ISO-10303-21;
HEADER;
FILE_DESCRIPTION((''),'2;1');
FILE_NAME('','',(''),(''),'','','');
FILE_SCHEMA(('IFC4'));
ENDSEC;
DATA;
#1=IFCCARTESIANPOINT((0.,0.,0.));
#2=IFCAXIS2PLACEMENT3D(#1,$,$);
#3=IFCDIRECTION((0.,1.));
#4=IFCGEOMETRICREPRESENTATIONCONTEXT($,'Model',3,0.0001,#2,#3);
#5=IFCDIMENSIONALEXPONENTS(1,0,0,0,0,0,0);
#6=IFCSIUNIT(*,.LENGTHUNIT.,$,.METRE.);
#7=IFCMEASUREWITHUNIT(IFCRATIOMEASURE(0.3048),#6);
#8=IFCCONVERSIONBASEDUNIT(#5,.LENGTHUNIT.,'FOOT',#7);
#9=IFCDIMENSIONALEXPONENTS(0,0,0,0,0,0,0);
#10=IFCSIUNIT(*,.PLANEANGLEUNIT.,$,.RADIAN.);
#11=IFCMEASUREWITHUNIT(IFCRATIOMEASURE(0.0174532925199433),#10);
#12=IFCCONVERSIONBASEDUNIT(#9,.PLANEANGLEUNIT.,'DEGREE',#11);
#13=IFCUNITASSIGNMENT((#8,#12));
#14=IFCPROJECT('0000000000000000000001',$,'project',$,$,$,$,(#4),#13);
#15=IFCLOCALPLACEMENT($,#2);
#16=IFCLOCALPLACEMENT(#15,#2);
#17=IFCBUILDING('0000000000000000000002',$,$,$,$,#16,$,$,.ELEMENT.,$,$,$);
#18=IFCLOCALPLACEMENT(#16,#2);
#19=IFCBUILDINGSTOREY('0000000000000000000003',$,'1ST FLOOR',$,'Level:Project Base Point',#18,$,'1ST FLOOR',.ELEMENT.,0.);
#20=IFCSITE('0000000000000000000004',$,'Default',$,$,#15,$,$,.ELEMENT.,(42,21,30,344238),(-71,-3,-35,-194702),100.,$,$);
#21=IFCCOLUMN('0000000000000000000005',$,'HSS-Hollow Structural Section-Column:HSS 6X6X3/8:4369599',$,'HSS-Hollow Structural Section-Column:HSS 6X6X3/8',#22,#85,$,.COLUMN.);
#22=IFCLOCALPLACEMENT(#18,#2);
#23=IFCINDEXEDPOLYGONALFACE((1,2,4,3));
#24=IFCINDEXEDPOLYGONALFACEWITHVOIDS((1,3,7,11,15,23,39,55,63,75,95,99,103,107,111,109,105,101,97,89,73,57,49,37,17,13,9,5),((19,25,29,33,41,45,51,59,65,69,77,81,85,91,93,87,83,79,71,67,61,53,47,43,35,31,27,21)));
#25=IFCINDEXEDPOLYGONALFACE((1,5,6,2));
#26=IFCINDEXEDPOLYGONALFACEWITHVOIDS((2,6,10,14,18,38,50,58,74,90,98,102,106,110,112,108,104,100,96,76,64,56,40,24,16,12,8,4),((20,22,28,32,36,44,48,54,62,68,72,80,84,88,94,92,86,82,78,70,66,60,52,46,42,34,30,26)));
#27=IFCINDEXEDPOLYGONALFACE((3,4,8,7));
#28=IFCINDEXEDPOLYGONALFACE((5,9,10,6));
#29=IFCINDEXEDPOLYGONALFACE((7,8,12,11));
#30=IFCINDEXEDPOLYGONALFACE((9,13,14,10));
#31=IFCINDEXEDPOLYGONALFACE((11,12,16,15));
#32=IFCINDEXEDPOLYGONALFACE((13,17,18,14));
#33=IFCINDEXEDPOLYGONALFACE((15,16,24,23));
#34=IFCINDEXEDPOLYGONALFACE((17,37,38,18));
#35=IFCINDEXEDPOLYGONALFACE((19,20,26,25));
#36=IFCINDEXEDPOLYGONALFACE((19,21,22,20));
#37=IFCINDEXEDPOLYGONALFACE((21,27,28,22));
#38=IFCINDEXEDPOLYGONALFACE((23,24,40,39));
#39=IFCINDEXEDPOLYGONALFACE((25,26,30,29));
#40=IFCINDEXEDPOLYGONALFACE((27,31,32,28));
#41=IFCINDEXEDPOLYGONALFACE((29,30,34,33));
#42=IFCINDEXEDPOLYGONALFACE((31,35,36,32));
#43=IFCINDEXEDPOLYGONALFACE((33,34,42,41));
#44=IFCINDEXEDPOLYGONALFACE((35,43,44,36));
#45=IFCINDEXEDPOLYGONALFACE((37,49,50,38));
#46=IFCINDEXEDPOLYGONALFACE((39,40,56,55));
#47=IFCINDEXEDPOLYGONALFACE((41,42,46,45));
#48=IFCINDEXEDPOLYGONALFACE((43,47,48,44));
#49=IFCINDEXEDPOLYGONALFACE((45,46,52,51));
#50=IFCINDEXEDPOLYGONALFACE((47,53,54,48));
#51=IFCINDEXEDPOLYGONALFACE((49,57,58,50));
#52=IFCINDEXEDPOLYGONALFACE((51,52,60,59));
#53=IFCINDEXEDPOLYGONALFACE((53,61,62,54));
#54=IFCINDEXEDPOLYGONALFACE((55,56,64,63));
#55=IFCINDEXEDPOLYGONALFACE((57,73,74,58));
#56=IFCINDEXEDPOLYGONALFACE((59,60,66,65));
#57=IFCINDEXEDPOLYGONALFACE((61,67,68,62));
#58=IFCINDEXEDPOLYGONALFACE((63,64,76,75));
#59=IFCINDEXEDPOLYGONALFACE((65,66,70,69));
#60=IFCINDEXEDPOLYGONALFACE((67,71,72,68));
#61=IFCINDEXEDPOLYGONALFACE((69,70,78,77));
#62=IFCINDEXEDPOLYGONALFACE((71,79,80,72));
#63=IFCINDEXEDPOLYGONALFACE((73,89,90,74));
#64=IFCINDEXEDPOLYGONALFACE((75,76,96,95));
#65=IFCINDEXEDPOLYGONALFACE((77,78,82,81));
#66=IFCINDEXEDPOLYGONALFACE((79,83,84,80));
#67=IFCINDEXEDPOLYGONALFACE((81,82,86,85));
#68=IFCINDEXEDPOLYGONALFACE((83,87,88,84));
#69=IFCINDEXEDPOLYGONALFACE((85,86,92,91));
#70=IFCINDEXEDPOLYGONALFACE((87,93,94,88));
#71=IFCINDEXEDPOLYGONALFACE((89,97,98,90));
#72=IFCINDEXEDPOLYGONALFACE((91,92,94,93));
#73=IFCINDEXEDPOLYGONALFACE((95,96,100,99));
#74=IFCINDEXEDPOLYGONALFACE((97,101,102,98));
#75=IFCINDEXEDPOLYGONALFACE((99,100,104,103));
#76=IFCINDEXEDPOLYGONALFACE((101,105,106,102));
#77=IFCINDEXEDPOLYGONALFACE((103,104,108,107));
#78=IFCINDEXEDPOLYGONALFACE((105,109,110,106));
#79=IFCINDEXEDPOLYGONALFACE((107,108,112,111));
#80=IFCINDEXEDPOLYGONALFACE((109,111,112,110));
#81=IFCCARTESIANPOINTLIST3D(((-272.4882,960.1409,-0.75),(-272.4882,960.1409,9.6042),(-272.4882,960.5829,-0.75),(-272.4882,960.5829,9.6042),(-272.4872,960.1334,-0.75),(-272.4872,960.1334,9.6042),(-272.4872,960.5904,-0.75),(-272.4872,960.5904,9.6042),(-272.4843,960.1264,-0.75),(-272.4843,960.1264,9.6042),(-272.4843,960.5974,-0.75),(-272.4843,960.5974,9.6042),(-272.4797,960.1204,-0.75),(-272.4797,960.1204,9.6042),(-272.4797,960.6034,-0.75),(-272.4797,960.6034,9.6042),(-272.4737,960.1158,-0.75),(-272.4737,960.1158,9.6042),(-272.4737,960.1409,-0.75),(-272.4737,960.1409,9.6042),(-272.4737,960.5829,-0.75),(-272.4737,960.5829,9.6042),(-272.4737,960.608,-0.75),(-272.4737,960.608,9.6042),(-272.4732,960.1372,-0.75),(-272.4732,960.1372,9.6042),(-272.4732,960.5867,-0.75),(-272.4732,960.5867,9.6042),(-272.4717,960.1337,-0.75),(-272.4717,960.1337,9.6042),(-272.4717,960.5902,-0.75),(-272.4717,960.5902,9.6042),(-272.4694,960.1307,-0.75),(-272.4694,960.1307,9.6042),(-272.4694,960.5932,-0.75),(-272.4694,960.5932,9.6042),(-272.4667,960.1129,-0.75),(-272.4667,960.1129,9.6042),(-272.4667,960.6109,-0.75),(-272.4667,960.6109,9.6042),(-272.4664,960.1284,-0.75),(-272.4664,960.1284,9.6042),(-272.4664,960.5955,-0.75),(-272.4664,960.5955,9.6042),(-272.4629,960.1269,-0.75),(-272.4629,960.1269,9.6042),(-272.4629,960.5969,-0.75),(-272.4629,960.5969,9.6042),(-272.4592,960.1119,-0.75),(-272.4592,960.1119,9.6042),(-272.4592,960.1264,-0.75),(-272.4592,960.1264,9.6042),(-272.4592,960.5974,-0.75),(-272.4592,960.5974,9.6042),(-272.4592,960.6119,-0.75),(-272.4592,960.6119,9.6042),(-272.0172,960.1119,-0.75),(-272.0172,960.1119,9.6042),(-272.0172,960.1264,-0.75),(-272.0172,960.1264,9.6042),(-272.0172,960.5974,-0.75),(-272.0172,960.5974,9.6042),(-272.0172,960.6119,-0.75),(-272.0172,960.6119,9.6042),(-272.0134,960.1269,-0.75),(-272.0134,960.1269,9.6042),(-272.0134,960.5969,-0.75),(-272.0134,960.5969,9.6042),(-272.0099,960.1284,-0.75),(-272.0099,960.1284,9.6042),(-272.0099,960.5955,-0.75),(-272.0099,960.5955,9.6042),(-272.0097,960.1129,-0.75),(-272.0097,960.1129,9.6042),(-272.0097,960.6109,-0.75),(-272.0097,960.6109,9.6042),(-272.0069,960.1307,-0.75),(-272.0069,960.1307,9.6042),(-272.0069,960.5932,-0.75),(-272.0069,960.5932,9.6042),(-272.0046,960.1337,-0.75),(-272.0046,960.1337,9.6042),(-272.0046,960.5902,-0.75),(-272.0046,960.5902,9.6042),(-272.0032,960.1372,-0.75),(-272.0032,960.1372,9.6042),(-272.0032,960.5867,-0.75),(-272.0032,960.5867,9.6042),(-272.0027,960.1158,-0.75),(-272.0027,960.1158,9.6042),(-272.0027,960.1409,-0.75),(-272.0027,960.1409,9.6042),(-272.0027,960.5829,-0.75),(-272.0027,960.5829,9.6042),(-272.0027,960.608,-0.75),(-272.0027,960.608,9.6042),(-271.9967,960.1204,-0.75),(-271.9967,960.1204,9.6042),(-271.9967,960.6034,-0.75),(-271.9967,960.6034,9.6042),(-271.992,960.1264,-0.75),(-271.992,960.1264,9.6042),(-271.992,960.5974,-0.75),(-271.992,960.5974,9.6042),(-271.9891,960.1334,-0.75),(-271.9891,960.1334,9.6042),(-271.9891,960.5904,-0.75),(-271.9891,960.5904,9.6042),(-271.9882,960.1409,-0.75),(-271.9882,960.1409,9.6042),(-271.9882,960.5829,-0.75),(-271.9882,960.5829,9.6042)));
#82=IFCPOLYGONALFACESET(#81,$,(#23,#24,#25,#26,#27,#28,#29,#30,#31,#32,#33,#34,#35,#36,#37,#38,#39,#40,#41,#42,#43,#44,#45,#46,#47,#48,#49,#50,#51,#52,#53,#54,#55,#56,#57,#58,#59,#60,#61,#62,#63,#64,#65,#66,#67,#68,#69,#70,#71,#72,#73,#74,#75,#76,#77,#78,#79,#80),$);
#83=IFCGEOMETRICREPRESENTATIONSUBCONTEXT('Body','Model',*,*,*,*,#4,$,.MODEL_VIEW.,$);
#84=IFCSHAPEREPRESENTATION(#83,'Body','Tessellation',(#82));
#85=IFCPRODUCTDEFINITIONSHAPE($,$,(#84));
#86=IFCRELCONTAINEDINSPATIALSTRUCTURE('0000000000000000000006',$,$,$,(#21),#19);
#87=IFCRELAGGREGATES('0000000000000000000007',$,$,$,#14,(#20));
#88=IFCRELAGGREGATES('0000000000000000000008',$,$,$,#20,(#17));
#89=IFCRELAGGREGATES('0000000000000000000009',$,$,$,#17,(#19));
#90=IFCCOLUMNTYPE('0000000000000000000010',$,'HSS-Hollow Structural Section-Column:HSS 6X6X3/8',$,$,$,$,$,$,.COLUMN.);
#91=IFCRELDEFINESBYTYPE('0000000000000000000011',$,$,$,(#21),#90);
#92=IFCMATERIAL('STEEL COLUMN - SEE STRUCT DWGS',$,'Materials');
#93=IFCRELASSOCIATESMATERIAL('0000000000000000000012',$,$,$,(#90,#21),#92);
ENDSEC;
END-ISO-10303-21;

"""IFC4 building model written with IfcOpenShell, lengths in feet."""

from ifc_helpers import new_model, entity, si_unit, converted_unit, direction, frame, frame_2d, origin, place, context, subcontext, project, spatial, polyline, circle_curve, parameter, trimmed, segment, composite_curve, outline, extrude, source, transform, mapped, material, material_profile, profile_set, profile_usage, type_object, type_shapes, element, save


model = new_model("IFC4")

# Units and contexts
model_context = context("Model", 3, precision=0.0001, world=origin(), true_north=direction((0.0, 1.0)))
body_context = subcontext(model_context, "Body", "Model", "MODEL_VIEW")
ifc_project = project(units=[converted_unit("LENGTHUNIT", "FOOT", entity("IfcRatioMeasure", 0.3048), si_unit("LENGTHUNIT", "METRE"), dimensions=[1, 0, 0, 0, 0, 0, 0]), converted_unit("PLANEANGLEUNIT", "DEGREE", entity("IfcRatioMeasure", 0.0174532925199433), si_unit("PLANEANGLEUNIT", "RADIAN"), dimensions=[0, 0, 0, 0, 0, 0, 0])], contexts=[model_context])

# Site, building, storey
site_placement = place(None, origin())
site = spatial("IfcSite", under=ifc_project, at=site_placement, Name="Default", CompositionType="ELEMENT", RefLatitude=(42, 21, 30, 344238), RefLongitude=(-71, -3, -35, -194702), RefElevation=100.0)
building_placement = place(site_placement, origin())
building = spatial("IfcBuilding", under=site, at=building_placement, CompositionType="ELEMENT")
storey_placement = place(building_placement, origin())
storey = spatial("IfcBuildingStorey", under=building, at=storey_placement, Name="1ST FLOOR", ObjectType="Level:Project Base Point", LongName="1ST FLOOR", CompositionType="ELEMENT", Elevation=0.0)

# Column
ifc_material_1 = material(Name="STEEL COLUMN - SEE STRUCT DWGS", Category="Materials")
ifc_material_profile_1 = material_profile(ifc_material_1, outline(composite_curve([segment(trimmed(circle_curve(frame_2d((0.221, -0.221), x_axis=(1.0, 0.0)), 0.029), [parameter(270.0)], [parameter(0.0)], True, "PARAMETER"), True, "CONTINUOUS"), segment(polyline([(0.25, -0.221), (0.25, 0.221)]), True, "CONTINUOUS"), segment(trimmed(circle_curve(frame_2d((0.221, 0.221), x_axis=(1.0, 0.0)), 0.029), [parameter(0.0)], [parameter(90.0)], True, "PARAMETER"), True, "CONTINUOUS"), segment(polyline([(0.221, 0.25), (-0.221, 0.25)]), True, "CONTINUOUS"), segment(trimmed(circle_curve(frame_2d((-0.221, 0.221), x_axis=(1.0, 0.0)), 0.029), [parameter(90.0)], [parameter(180.0)], True, "PARAMETER"), True, "CONTINUOUS"), segment(polyline([(-0.25, 0.221), (-0.25, -0.221)]), True, "CONTINUOUS"), segment(trimmed(circle_curve(frame_2d((-0.221, -0.221), x_axis=(1.0, 0.0)), 0.029), [parameter(180.0)], [parameter(270.0)], True, "PARAMETER"), True, "CONTINUOUS"), segment(polyline([(-0.221, -0.25), (0.221, -0.25)]), True, "CONTINUOUS")], self_intersect=False), holes=[composite_curve([segment(polyline([(0.221, -0.2355), (-0.221, -0.2355)]), True, "CONTINUOUS"), segment(trimmed(circle_curve(frame_2d((-0.221, -0.221), x_axis=(1.0, 0.0)), 0.0145), [parameter(180.0)], [parameter(270.0)], True, "PARAMETER"), False, "CONTINUOUS"), segment(polyline([(-0.2355, -0.221), (-0.2355, 0.221)]), True, "CONTINUOUS"), segment(trimmed(circle_curve(frame_2d((-0.221, 0.221), x_axis=(1.0, 0.0)), 0.0145), [parameter(90.0)], [parameter(180.0)], True, "PARAMETER"), False, "CONTINUOUS"), segment(polyline([(-0.221, 0.2355), (0.221, 0.2355)]), True, "CONTINUOUS"), segment(trimmed(circle_curve(frame_2d((0.221, 0.221), x_axis=(1.0, 0.0)), 0.0145), [parameter(0.0)], [parameter(90.0)], True, "PARAMETER"), False, "CONTINUOUS"), segment(polyline([(0.2355, 0.221), (0.2355, -0.221)]), True, "CONTINUOUS"), segment(trimmed(circle_curve(frame_2d((0.221, -0.221), x_axis=(1.0, 0.0)), 0.0145), [parameter(270.0)], [parameter(0.0)], True, "PARAMETER"), False, "CONTINUOUS")], self_intersect=False)]), Name="HSS 6X6X3/8")
ifc_profile_set_1 = profile_set([ifc_material_profile_1], Name="HSS 6X6X3/8")
ifc_profile_usage_1 = profile_usage(ifc_profile_set_1)
column_type_1 = type_object("IfcColumnType", Name="HSS-Hollow Structural Section-Column:HSS 6X6X3/8", PredefinedType="COLUMN", material=ifc_profile_set_1)
shared_shape_1 = source(origin(), body_context, "Body", "SweptSolid", [
    extrude(outline(composite_curve([segment(trimmed(circle_curve(frame_2d((0.221, -0.221), x_axis=(1.0, 0.0)), 0.029), [parameter(270.0)], [parameter(0.0)], True, "PARAMETER"), True, "CONTINUOUS"), segment(polyline([(0.25, -0.221), (0.25, 0.221)]), True, "CONTINUOUS"), segment(trimmed(circle_curve(frame_2d((0.221, 0.221), x_axis=(1.0, 0.0)), 0.029), [parameter(0.0)], [parameter(90.0)], True, "PARAMETER"), True, "CONTINUOUS"), segment(polyline([(0.221, 0.25), (-0.221, 0.25)]), True, "CONTINUOUS"), segment(trimmed(circle_curve(frame_2d((-0.221, 0.221), x_axis=(1.0, 0.0)), 0.029), [parameter(90.0)], [parameter(180.0)], True, "PARAMETER"), True, "CONTINUOUS"), segment(polyline([(-0.25, 0.221), (-0.25, -0.221)]), True, "CONTINUOUS"), segment(trimmed(circle_curve(frame_2d((-0.221, -0.221), x_axis=(1.0, 0.0)), 0.029), [parameter(180.0)], [parameter(270.0)], True, "PARAMETER"), True, "CONTINUOUS"), segment(polyline([(-0.221, -0.25), (0.221, -0.25)]), True, "CONTINUOUS")], self_intersect=False), holes=[composite_curve([segment(polyline([(0.221, -0.2355), (-0.221, -0.2355)]), True, "CONTINUOUS"), segment(trimmed(circle_curve(frame_2d((-0.221, -0.221), x_axis=(1.0, 0.0)), 0.0145), [parameter(180.0)], [parameter(270.0)], True, "PARAMETER"), False, "CONTINUOUS"), segment(polyline([(-0.2355, -0.221), (-0.2355, 0.221)]), True, "CONTINUOUS"), segment(trimmed(circle_curve(frame_2d((-0.221, 0.221), x_axis=(1.0, 0.0)), 0.0145), [parameter(90.0)], [parameter(180.0)], True, "PARAMETER"), False, "CONTINUOUS"), segment(polyline([(-0.221, 0.2355), (0.221, 0.2355)]), True, "CONTINUOUS"), segment(trimmed(circle_curve(frame_2d((0.221, 0.221), x_axis=(1.0, 0.0)), 0.0145), [parameter(0.0)], [parameter(90.0)], True, "PARAMETER"), False, "CONTINUOUS"), segment(polyline([(0.2355, 0.221), (0.2355, -0.221)]), True, "CONTINUOUS"), segment(trimmed(circle_curve(frame_2d((0.221, -0.221), x_axis=(1.0, 0.0)), 0.0145), [parameter(270.0)], [parameter(0.0)], True, "PARAMETER"), False, "CONTINUOUS")], self_intersect=False)]), frame((0.2552, 0.2552, 0.0), z_axis=(0.0, 0.0, 1.0), x_axis=(-1.0, 0.0, 0.0)), (0.0, 0.0, 1.0), 10.3542),
])
type_shapes(column_type_1, [shared_shape_1])
column_1_placement = place(storey_placement, frame((-272.4934, 960.1067, -0.75)))
element("IfcColumn", 1, at=column_1_placement, inside=storey, type_object=column_type_1, material=ifc_profile_usage_1, Name="HSS-Hollow Structural Section-Column:HSS 6X6X3/8:4369599", ObjectType="HSS-Hollow Structural Section-Column:HSS 6X6X3/8", PredefinedType="COLUMN", context=body_context, shape_type="MappedRepresentation", body=[
    mapped(shared_shape_1, transform((0.0, 0.0, 0.0), scale=1.0)),
])

save(model, "model.ifc")
